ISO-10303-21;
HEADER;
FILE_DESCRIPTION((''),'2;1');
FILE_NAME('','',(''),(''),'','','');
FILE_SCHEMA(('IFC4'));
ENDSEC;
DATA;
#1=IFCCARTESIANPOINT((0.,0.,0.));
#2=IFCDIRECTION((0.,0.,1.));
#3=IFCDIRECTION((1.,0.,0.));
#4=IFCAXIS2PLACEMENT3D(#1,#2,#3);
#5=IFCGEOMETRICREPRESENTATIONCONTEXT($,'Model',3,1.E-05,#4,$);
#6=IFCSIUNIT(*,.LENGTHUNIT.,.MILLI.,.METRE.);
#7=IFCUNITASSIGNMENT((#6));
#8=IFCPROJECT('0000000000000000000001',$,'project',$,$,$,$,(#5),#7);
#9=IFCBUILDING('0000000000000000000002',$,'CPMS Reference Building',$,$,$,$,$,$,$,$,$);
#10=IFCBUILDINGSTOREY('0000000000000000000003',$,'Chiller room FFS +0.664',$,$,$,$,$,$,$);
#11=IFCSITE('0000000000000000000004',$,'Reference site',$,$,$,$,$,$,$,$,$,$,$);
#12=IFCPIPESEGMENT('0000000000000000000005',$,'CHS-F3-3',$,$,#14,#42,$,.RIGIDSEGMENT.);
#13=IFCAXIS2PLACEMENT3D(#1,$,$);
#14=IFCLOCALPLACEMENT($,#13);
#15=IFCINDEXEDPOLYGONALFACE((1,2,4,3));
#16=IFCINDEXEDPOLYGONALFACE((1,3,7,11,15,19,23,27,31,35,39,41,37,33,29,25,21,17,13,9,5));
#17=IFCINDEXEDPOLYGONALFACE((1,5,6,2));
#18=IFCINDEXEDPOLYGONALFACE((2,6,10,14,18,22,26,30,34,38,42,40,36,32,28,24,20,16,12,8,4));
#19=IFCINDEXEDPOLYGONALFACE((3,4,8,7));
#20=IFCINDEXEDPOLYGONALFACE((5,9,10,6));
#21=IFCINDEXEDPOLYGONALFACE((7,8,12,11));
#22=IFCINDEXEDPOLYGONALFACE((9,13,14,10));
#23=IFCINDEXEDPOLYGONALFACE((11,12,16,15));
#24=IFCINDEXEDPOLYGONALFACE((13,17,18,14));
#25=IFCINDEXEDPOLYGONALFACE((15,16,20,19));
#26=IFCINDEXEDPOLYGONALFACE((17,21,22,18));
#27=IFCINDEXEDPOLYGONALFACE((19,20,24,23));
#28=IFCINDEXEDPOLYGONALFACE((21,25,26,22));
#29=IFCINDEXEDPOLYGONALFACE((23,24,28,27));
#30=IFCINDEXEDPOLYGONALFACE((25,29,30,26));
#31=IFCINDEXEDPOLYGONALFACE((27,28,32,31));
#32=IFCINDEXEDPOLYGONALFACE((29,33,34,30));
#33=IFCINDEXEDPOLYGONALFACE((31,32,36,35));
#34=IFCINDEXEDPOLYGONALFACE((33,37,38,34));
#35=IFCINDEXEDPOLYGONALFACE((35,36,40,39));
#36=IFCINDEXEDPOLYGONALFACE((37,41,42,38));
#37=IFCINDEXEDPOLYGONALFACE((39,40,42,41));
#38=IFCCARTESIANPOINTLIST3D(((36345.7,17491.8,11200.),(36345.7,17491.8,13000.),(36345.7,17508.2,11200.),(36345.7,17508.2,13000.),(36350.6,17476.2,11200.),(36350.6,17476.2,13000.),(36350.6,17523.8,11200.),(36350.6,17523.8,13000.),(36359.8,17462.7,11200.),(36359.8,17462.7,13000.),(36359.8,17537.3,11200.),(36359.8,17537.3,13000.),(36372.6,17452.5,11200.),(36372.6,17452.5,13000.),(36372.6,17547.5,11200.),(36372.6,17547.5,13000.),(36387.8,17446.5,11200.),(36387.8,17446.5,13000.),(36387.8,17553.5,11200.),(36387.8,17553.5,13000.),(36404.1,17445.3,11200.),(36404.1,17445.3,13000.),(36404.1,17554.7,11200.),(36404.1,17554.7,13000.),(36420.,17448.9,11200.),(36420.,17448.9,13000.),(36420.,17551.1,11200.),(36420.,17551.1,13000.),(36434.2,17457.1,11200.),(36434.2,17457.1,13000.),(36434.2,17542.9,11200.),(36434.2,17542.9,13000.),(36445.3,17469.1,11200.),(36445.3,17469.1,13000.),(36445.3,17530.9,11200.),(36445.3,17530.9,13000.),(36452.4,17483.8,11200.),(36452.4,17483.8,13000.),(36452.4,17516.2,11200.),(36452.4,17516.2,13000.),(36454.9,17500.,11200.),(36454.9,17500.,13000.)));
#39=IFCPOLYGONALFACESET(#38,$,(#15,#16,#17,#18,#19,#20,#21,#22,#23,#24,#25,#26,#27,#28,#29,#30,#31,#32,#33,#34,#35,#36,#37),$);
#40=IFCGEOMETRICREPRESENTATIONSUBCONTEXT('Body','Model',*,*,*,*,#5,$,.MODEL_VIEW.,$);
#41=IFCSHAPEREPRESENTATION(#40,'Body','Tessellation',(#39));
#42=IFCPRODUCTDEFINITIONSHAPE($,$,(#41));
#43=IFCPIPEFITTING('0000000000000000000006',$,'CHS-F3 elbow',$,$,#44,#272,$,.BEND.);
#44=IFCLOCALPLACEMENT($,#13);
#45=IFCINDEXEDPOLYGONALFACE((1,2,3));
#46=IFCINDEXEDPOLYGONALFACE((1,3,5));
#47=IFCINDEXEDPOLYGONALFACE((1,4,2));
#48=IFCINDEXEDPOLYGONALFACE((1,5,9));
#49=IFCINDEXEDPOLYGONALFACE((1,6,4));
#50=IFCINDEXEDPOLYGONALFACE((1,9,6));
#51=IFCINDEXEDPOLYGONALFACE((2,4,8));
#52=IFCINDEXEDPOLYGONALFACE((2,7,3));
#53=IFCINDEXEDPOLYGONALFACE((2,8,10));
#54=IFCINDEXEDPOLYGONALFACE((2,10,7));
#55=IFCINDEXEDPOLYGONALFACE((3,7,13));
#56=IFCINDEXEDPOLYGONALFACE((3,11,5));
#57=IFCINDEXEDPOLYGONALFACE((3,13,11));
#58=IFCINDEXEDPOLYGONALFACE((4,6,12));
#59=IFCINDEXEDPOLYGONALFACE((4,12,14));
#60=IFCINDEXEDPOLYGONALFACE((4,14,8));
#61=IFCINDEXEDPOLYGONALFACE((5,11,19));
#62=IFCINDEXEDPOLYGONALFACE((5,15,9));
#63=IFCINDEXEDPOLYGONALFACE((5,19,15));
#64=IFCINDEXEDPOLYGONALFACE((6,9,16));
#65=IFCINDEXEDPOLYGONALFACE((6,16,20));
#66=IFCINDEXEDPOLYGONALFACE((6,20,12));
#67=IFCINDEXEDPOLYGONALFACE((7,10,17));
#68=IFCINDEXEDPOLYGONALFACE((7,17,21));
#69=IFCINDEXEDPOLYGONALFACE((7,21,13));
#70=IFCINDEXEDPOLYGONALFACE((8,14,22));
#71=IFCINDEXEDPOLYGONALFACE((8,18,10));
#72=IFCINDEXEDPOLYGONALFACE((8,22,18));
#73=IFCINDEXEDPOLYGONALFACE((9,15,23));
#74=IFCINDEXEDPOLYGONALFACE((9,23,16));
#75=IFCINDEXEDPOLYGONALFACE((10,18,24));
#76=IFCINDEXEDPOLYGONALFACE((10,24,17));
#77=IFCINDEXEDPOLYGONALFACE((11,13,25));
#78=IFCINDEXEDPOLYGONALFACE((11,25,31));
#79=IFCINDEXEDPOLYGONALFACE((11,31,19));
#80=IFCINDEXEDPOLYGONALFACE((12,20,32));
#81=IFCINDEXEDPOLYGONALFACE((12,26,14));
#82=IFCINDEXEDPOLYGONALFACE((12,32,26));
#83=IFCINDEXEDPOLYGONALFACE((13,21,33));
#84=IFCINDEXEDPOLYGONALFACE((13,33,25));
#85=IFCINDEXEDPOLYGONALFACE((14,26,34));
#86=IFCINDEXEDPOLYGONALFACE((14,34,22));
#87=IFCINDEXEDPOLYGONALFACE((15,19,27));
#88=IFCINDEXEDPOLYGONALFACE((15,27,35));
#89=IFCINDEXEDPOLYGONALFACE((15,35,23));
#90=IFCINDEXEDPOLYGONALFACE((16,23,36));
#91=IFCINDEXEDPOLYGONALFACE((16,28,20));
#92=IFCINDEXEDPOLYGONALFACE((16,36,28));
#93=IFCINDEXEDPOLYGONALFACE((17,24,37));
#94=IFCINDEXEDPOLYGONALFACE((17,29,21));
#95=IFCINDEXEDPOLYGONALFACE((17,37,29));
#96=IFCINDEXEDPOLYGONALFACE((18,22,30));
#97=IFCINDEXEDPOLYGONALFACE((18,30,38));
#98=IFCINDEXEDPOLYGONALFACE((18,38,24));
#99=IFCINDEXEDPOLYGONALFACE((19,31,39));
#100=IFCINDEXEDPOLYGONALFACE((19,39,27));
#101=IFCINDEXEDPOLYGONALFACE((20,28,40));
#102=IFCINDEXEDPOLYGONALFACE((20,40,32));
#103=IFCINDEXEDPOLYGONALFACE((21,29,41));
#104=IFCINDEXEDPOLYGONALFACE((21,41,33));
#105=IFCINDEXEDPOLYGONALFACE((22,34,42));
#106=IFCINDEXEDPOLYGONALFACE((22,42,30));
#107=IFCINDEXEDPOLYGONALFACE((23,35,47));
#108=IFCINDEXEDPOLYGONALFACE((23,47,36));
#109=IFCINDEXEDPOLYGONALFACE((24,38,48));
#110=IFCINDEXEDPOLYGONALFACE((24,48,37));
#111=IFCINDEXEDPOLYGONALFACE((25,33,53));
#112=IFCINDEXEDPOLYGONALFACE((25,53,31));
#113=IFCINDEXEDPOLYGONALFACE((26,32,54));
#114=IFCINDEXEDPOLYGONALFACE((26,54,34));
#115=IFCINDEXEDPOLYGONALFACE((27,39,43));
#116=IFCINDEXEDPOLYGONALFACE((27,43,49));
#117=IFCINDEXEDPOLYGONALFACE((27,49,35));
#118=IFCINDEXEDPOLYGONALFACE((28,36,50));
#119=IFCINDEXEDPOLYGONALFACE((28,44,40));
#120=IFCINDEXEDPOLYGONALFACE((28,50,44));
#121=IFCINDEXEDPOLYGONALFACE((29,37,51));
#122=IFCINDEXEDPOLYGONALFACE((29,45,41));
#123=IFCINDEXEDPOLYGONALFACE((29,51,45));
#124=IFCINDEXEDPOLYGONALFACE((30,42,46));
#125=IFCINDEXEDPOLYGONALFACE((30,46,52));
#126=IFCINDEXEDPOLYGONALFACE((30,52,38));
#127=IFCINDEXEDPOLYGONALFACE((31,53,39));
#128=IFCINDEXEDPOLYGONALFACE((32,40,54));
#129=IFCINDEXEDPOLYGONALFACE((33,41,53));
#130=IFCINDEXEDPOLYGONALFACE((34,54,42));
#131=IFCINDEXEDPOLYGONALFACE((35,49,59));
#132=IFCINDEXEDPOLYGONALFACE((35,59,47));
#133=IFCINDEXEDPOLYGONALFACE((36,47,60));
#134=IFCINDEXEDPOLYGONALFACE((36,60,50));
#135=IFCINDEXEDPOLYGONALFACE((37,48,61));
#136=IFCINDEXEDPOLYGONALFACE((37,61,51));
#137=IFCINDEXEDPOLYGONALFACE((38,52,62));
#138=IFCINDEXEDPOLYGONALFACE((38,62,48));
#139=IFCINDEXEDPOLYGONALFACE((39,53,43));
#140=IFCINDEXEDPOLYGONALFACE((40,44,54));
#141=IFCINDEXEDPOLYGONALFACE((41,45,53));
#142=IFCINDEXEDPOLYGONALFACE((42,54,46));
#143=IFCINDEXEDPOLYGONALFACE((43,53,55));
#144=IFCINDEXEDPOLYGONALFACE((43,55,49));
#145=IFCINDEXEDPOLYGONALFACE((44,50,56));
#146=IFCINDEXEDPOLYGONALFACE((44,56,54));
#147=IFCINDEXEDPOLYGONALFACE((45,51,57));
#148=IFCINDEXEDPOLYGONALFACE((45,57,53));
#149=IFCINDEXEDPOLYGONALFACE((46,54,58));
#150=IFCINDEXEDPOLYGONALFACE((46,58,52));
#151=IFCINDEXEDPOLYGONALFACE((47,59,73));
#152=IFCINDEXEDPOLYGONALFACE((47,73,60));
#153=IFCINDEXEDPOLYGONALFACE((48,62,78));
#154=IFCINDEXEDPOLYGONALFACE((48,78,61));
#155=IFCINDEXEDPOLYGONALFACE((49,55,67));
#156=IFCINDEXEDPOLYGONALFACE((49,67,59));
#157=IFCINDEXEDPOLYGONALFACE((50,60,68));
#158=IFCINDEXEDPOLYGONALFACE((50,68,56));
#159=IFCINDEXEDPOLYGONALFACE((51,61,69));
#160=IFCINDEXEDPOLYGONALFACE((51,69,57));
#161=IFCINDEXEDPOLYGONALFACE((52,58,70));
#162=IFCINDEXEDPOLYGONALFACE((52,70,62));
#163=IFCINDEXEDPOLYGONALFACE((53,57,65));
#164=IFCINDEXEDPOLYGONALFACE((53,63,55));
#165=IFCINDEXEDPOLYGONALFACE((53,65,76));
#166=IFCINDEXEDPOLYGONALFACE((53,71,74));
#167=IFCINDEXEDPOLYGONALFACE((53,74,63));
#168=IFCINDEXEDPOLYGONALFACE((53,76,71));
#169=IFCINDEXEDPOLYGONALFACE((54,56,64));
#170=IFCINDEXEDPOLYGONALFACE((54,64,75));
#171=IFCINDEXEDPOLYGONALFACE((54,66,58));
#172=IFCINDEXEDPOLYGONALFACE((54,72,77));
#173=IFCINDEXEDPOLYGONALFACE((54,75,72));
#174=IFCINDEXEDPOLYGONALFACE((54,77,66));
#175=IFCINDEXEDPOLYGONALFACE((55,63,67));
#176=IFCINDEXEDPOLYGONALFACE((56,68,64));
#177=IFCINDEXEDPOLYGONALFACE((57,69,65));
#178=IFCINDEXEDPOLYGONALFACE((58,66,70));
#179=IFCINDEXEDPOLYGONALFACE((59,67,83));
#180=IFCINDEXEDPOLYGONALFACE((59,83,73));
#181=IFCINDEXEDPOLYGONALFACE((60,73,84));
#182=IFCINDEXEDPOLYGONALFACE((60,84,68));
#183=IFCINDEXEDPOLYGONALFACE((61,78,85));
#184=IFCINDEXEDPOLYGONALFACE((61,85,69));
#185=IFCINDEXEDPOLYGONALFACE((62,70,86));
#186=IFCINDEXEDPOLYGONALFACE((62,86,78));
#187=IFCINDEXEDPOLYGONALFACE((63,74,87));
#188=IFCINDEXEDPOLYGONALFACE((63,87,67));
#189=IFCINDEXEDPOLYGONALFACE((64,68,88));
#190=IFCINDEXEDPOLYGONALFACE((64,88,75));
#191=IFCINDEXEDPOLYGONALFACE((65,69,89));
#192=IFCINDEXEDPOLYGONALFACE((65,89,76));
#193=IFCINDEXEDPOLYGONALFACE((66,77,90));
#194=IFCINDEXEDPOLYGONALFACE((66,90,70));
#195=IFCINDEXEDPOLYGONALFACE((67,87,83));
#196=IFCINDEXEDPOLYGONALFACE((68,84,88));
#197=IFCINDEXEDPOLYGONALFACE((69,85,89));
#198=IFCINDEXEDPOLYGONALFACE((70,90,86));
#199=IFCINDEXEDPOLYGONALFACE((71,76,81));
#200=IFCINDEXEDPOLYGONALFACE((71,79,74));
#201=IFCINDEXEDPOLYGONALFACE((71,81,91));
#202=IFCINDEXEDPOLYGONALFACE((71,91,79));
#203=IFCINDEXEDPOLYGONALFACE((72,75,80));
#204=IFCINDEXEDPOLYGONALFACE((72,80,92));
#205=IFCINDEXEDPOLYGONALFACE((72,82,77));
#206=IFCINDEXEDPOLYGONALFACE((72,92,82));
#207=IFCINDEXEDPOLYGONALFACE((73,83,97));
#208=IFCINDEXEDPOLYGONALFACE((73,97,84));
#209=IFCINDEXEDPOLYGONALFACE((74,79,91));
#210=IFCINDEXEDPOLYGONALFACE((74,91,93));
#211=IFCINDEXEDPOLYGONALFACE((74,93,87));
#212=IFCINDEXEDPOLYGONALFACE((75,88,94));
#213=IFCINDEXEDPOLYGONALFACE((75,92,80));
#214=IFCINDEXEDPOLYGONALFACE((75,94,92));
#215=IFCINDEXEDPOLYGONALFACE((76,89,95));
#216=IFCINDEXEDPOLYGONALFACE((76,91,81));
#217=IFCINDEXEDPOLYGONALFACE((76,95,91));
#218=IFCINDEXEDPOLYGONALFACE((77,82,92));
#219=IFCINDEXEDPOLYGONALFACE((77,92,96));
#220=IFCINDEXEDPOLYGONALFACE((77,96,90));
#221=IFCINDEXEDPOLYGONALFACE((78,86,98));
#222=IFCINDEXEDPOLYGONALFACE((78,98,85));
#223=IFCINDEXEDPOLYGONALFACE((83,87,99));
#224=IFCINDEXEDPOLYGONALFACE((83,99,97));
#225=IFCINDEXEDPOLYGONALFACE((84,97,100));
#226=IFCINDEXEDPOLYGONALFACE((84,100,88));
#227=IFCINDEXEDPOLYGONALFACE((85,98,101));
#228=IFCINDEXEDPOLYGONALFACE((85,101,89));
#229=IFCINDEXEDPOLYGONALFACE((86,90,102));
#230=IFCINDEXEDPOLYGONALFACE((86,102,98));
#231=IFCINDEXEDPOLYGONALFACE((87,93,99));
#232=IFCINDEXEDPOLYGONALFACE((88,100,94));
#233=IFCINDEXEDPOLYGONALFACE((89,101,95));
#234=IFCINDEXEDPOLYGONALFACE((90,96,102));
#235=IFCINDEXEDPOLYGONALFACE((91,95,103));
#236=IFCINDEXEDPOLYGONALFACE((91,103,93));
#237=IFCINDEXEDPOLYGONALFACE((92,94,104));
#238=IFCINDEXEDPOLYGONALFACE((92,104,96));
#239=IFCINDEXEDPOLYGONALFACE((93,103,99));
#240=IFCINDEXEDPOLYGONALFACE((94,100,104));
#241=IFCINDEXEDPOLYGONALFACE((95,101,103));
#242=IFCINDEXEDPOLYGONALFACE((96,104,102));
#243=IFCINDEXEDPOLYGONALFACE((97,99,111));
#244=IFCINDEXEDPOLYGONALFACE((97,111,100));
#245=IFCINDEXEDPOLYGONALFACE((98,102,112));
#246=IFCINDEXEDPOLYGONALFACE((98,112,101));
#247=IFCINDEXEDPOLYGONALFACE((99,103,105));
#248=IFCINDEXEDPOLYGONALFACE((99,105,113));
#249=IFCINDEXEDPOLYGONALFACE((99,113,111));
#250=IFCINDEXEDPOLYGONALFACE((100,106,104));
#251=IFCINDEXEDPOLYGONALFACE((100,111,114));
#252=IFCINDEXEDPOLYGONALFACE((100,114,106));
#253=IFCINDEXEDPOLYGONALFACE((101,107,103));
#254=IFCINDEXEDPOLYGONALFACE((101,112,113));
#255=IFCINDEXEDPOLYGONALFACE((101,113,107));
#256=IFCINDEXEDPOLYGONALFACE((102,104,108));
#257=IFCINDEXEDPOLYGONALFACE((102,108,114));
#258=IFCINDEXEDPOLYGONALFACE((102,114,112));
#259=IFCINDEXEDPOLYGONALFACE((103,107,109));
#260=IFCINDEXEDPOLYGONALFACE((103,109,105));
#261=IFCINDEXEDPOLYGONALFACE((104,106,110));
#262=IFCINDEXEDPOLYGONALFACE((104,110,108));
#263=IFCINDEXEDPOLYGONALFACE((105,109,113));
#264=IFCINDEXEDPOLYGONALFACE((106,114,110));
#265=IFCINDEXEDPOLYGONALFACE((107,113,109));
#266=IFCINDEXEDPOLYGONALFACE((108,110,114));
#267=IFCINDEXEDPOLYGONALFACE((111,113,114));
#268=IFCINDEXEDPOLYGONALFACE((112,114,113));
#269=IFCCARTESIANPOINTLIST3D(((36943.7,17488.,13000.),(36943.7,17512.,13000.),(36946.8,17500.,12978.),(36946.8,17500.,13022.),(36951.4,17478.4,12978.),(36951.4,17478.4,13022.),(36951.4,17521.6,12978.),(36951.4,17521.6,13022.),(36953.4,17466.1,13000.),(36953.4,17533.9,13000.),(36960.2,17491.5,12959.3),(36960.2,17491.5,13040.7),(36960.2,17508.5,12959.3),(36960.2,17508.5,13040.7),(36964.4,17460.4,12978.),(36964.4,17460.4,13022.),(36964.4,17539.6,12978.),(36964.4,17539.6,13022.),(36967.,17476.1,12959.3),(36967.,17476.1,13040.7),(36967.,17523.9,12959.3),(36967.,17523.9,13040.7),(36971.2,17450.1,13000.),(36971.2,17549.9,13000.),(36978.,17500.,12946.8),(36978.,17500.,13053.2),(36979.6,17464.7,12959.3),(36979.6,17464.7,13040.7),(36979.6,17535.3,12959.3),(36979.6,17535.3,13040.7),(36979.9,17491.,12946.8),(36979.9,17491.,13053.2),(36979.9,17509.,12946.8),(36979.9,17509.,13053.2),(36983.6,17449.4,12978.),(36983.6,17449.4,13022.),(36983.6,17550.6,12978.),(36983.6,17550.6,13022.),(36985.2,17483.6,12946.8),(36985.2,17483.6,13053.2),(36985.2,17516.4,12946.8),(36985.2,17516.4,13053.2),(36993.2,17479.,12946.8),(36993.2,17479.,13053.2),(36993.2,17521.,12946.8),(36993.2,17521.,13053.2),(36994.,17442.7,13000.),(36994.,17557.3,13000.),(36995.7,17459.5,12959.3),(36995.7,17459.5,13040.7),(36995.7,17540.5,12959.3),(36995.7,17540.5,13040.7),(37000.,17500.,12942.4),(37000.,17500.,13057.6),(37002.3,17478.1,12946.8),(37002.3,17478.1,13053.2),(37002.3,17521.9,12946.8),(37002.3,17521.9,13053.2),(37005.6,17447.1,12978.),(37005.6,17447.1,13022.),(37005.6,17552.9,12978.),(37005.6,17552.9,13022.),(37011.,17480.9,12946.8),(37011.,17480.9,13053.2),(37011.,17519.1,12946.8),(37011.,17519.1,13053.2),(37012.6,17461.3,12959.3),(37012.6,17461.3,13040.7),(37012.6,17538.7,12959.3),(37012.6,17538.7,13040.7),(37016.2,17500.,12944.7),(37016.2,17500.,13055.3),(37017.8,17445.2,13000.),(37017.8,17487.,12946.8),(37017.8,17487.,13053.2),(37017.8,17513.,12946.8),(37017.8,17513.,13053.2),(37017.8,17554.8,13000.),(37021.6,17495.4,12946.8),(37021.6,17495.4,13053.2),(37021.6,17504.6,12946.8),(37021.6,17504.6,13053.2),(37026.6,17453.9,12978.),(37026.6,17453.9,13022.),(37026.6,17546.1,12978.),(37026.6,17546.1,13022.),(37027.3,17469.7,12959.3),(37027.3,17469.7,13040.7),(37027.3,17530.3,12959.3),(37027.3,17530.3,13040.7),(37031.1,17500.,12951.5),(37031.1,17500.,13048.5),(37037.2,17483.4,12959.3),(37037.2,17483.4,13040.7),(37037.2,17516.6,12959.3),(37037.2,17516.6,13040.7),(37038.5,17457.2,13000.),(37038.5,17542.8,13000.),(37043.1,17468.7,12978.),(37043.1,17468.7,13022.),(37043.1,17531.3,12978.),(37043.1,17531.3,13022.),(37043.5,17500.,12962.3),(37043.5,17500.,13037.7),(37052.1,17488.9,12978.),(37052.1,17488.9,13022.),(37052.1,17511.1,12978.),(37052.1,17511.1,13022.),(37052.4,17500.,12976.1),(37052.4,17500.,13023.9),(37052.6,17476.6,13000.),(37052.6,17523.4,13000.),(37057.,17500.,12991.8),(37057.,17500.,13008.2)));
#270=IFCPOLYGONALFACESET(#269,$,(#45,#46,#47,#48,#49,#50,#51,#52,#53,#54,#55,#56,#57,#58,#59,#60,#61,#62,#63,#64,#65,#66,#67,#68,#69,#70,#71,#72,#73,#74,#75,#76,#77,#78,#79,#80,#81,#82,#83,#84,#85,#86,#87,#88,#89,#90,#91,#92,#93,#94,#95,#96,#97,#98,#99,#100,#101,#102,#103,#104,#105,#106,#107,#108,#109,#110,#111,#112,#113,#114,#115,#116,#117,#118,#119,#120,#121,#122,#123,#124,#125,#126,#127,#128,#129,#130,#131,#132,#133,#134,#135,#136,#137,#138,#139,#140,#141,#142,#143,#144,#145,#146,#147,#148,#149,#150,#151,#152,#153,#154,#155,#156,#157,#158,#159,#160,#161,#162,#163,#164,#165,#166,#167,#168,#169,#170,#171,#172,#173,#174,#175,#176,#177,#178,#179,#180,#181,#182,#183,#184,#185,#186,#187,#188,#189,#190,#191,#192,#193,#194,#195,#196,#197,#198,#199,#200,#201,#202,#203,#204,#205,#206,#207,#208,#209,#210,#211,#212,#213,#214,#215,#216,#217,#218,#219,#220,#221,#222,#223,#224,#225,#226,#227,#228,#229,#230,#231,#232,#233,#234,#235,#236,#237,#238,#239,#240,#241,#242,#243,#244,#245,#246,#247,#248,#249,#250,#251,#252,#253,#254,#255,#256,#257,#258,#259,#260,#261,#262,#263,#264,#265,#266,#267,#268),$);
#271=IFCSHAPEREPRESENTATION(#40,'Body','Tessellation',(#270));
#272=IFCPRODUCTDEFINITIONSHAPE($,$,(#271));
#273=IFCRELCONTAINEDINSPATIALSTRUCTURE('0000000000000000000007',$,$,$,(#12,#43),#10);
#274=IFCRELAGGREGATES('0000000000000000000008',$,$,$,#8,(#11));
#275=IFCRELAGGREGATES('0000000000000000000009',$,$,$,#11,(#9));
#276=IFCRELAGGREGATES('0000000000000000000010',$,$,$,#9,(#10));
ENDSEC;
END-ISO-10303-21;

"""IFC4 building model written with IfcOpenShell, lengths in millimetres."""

from ifc_helpers import new_model, entity, si_unit, frame, origin_with_axes, origin_2d, place, context, subcontext, project, spatial, circle_curve, outline, extrude, element, save


model = new_model("IFC4")

# Units and contexts
model_context = context("Model", 3, precision=1e-05, world=origin_with_axes())
body_context = subcontext(model_context, "Body", "Model", "MODEL_VIEW")
ifc_project = project(units=[si_unit("LENGTHUNIT", "METRE", prefix="MILLI")], contexts=[model_context])

# Site, building, storey
site = spatial("IfcSite", under=ifc_project, Name="Reference site")
building = spatial("IfcBuilding", under=site, Name="CPMS Reference Building")
storey = spatial("IfcBuildingStorey", under=building, Name="Chiller room FFS +0.664")

# Pipe segment
pipe_segment_1_placement = place(None, origin_with_axes())
element("IfcPipeSegment", 1, at=pipe_segment_1_placement, inside=storey, Name="CHS-F3-3", PredefinedType="RIGIDSEGMENT", context=body_context, shape_type="SweptSolid", body=[
    extrude(outline(circle_curve(origin_2d(), 54.9)), frame((36400.0, 17500.0, 13000.0), z_axis=(0.0, 0.0, -1.0), x_axis=(1.0, 0.0, 0.0)), (0.0, 0.0, 1.0), 1800.0),
])

# Pipe fitting
pipe_fitting_1_placement = place(None, origin_with_axes())
element("IfcPipeFitting", 2, at=pipe_fitting_1_placement, inside=storey, Name="CHS-F3 elbow", PredefinedType="BEND", context=body_context, shape_type="CSG", body=[
    entity("IfcSphere", entity("IfcAxis2Placement3D", entity("IfcCartesianPoint", [37000.0, 17500.0, 13000.0]), entity("IfcDirection", [0.0, 0.0, 1.0]), entity("IfcDirection", [1.0, 0.0, 0.0])), 57.6),
])

save(model, "model.ifc")
